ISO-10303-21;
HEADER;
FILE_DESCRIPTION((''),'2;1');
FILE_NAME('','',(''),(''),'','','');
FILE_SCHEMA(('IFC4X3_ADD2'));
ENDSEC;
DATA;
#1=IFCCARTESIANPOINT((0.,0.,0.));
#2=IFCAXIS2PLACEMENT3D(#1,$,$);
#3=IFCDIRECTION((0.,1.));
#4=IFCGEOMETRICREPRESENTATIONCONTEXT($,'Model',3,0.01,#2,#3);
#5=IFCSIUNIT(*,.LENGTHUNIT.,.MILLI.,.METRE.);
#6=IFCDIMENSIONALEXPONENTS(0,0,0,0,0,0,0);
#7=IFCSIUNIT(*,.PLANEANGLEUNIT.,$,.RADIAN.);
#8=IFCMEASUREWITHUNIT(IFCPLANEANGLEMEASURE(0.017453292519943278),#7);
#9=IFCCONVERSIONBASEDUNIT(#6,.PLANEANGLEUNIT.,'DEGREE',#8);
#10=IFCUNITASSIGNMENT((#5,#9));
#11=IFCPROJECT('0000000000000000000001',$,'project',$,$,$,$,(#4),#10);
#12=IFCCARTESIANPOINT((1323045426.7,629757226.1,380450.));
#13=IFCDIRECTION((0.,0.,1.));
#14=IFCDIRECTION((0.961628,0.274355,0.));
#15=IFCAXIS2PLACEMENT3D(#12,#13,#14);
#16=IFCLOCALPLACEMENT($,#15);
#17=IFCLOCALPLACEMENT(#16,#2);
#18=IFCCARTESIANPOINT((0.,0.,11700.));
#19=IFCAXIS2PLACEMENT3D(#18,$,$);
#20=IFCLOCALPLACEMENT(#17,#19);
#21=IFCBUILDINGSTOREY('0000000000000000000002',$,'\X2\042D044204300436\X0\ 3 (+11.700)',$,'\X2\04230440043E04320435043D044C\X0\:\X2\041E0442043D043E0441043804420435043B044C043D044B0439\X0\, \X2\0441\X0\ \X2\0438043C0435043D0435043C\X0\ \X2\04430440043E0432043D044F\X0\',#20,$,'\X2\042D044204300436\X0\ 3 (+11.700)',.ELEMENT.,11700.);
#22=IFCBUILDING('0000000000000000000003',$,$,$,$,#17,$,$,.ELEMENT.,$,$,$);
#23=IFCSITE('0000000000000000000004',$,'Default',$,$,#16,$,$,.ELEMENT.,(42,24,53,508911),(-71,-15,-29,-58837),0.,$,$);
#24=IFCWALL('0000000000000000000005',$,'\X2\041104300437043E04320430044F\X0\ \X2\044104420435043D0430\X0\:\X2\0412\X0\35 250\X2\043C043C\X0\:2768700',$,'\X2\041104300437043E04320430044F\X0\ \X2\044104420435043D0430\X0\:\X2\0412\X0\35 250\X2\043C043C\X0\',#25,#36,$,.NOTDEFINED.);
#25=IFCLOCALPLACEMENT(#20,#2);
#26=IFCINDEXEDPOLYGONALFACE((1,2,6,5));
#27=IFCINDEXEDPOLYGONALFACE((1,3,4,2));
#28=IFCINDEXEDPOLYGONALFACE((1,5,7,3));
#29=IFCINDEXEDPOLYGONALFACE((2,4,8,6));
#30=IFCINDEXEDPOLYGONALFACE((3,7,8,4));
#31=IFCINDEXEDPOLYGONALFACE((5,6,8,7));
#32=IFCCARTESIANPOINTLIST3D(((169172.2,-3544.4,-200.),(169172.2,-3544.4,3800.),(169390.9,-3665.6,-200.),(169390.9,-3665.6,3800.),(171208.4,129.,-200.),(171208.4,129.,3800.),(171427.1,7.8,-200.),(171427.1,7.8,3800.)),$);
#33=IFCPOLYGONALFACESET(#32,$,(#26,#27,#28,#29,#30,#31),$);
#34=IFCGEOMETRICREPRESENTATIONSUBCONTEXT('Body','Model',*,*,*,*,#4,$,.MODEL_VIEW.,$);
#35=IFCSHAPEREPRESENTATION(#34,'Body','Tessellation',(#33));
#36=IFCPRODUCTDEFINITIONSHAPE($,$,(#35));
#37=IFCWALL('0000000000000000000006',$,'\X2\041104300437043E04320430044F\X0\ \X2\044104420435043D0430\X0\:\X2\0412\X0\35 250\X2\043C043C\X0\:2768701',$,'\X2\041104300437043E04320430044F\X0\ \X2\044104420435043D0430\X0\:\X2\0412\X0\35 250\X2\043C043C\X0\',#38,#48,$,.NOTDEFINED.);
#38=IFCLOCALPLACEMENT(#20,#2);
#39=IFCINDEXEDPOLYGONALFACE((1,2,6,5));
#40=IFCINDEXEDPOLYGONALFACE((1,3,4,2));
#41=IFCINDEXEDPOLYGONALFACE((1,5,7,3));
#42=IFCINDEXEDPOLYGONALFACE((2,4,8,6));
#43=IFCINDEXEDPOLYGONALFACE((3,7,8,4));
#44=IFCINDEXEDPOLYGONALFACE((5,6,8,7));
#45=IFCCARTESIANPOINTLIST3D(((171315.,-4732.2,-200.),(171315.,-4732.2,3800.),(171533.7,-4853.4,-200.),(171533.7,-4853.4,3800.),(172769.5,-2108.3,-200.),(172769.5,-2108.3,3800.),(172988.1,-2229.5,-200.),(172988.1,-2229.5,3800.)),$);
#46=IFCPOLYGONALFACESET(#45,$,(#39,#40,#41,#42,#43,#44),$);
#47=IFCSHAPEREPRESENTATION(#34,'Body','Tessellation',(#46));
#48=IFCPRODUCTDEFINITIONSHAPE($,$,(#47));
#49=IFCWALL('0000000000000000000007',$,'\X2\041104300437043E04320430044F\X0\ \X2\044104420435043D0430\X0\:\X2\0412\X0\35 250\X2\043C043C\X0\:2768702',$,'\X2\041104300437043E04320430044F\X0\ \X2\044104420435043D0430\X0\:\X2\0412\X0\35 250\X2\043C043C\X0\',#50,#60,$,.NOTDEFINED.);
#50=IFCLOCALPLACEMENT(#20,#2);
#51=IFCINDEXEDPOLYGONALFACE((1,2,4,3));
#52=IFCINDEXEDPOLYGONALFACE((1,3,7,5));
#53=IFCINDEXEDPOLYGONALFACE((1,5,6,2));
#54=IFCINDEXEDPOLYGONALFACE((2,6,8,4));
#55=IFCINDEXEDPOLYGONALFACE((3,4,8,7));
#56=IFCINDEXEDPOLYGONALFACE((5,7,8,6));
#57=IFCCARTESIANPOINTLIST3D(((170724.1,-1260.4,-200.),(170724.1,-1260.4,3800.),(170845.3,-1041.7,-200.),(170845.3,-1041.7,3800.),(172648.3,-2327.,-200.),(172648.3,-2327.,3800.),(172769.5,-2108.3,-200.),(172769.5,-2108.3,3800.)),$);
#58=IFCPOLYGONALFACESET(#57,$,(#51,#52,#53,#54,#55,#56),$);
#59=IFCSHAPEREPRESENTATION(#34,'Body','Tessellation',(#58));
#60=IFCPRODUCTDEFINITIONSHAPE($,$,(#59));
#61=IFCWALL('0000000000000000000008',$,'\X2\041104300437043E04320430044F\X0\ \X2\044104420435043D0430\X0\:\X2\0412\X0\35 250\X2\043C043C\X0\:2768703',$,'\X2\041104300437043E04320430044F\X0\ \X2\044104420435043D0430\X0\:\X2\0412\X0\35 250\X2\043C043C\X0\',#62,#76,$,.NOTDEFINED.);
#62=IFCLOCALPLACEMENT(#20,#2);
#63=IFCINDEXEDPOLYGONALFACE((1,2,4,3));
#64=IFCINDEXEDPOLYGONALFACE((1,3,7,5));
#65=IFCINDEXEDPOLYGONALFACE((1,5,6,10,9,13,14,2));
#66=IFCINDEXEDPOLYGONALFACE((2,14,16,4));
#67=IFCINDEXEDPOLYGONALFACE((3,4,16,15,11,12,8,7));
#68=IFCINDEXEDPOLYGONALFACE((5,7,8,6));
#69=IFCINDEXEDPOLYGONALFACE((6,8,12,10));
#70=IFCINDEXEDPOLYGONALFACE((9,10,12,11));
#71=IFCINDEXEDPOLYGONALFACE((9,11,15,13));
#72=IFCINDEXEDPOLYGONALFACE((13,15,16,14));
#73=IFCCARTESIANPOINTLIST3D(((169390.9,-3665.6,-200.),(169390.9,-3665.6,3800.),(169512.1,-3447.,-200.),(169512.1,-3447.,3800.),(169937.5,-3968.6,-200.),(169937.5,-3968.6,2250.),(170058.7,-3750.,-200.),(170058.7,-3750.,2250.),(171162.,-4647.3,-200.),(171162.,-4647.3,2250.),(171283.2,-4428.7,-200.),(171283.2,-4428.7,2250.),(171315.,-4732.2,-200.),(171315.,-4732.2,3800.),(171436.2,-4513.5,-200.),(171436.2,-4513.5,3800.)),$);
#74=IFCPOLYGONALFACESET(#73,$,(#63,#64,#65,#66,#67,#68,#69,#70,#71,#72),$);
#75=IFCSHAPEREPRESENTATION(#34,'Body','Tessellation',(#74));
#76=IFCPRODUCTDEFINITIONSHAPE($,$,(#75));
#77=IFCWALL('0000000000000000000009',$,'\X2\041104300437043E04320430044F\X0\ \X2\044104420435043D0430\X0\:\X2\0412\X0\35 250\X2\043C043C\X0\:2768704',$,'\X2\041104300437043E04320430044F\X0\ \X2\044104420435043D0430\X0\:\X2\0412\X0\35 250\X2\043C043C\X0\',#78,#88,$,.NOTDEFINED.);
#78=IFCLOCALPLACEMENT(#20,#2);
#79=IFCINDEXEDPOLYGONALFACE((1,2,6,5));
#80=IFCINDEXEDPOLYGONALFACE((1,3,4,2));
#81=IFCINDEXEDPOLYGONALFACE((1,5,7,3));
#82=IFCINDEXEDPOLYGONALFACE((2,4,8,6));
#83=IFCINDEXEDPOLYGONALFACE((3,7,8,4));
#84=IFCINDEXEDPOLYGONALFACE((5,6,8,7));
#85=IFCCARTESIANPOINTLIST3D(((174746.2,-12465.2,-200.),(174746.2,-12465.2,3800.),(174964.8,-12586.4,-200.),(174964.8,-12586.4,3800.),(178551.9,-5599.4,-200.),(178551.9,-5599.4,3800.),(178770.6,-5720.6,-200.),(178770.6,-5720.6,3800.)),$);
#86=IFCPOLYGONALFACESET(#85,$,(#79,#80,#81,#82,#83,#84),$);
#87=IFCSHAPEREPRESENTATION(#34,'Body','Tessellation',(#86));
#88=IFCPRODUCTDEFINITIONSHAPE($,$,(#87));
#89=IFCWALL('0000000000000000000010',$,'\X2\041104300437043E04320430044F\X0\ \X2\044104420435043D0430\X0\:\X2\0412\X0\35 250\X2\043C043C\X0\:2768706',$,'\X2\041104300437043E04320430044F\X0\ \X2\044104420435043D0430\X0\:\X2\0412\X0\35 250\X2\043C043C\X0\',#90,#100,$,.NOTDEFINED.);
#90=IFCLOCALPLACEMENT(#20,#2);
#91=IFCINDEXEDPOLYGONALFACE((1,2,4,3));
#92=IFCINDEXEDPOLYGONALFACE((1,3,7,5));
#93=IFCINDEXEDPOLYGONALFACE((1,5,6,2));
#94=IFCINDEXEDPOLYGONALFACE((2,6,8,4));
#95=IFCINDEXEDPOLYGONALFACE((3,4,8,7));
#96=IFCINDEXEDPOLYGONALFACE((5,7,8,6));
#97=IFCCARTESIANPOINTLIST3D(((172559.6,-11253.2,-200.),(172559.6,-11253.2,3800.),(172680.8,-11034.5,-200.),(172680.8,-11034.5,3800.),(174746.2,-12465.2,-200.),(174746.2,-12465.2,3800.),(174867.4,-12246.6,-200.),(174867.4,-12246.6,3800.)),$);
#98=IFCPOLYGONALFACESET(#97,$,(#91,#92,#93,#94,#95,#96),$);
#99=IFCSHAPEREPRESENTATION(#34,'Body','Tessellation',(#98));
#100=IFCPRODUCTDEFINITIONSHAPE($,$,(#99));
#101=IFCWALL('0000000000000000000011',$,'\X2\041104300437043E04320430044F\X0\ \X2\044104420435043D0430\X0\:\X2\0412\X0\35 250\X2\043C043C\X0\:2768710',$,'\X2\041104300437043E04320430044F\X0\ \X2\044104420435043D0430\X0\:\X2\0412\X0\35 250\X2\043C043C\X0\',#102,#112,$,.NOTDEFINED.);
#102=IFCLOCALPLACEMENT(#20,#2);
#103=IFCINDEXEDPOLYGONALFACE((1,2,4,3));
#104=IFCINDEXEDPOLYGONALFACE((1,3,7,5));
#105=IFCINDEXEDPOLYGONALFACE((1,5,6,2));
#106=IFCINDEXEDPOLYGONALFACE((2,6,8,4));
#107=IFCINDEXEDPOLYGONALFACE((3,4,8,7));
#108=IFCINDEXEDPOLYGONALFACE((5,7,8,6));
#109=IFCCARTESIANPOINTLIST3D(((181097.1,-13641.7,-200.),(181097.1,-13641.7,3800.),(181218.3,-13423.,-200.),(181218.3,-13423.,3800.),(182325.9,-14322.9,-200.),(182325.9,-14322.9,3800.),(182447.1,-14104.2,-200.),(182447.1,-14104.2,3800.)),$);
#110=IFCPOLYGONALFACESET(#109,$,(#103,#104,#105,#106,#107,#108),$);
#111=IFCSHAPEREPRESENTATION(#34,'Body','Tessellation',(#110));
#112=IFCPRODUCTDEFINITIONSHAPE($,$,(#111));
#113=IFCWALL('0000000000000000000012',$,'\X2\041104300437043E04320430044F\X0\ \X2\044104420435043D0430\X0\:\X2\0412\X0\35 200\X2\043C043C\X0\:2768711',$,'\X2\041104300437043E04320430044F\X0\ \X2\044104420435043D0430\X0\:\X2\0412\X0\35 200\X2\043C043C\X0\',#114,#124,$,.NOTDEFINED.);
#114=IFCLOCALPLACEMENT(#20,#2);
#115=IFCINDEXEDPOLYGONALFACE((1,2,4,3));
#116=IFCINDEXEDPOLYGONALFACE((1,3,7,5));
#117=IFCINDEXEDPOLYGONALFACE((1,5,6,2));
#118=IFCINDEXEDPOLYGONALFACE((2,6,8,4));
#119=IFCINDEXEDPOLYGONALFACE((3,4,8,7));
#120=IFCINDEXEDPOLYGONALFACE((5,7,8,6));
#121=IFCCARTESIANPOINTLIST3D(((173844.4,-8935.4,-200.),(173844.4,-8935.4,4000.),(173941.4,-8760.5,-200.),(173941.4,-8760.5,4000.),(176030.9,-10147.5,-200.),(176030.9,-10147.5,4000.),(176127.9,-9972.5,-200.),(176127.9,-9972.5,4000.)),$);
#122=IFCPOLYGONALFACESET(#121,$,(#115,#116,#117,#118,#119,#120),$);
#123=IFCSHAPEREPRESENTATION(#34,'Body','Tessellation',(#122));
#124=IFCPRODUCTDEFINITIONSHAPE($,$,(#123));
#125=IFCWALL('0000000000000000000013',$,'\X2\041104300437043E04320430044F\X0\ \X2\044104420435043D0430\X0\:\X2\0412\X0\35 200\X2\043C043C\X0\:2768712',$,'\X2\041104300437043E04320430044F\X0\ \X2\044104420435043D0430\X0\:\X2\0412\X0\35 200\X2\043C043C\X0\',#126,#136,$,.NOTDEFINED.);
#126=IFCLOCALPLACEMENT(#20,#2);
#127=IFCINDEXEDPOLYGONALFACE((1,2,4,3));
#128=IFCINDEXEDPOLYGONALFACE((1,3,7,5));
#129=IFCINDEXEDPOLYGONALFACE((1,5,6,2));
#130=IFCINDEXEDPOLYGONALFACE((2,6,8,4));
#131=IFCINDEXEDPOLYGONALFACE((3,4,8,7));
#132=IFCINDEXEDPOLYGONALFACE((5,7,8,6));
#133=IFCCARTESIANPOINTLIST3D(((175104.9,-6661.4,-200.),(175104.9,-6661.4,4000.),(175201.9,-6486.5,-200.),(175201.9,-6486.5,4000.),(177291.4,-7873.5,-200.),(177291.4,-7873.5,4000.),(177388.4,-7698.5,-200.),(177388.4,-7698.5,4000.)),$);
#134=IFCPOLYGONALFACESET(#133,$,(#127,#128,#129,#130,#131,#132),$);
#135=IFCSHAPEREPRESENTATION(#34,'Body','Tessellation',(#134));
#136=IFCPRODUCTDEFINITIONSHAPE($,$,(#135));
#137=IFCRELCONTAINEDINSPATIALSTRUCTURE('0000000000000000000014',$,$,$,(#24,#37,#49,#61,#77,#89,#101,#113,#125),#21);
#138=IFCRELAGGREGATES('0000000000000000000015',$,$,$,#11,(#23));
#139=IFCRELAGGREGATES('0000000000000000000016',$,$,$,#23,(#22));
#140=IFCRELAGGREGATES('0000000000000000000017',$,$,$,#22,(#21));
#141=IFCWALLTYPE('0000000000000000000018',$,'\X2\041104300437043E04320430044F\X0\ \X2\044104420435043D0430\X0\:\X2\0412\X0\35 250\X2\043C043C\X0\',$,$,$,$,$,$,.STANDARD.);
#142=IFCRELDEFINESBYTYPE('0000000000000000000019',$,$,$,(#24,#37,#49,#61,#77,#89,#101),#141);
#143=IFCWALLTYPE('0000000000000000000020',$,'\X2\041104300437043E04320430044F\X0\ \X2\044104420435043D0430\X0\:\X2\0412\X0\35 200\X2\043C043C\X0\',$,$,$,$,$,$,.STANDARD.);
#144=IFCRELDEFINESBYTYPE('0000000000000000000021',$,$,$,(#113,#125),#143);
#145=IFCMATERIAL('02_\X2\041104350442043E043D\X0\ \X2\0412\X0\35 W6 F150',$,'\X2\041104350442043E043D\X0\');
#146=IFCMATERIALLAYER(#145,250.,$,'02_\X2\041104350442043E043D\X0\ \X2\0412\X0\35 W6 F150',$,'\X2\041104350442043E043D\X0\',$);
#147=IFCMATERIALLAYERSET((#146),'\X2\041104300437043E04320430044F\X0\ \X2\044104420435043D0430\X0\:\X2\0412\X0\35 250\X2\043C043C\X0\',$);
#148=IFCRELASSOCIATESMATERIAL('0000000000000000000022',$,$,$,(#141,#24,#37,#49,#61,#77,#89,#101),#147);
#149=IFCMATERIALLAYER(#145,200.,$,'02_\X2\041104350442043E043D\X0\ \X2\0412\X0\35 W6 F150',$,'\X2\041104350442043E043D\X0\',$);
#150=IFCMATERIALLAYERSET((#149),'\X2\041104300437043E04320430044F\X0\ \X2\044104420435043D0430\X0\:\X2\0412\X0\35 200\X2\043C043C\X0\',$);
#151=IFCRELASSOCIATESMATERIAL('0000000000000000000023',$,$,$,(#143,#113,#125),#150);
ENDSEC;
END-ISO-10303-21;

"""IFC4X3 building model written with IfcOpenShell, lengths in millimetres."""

from ifc_helpers import new_model, entity, si_unit, converted_unit, direction, frame, frame_2d, origin, origin_2d_with_axis, place, context, subcontext, project, spatial, rectangle, extrude, material, layer, layer_set, type_object, element, save


model = new_model("IFC4X3")

# Units and contexts
model_context = context("Model", 3, precision=0.01, world=origin(), true_north=direction((0.0, 1.0)))
body_context = subcontext(model_context, "Body", "Model", "MODEL_VIEW")
ifc_project = project(units=[si_unit("LENGTHUNIT", "METRE", prefix="MILLI"), converted_unit("PLANEANGLEUNIT", "DEGREE", entity("IfcPlaneAngleMeasure", 0.017453292519943278), si_unit("PLANEANGLEUNIT", "RADIAN"), dimensions=[0, 0, 0, 0, 0, 0, 0])], contexts=[model_context])

# Site, building, storey
site_placement = place(None, frame((1323045426.7, 629757226.1, 380450.0), z_axis=(0.0, 0.0, 1.0), x_axis=(0.961628, 0.274355, 0.0)))
site = spatial("IfcSite", under=ifc_project, at=site_placement, Name="Default", CompositionType="ELEMENT", RefLatitude=(42, 24, 53, 508911), RefLongitude=(-71, -15, -29, -58837), RefElevation=0.0)
building_placement = place(site_placement, origin())
building = spatial("IfcBuilding", under=site, at=building_placement, CompositionType="ELEMENT")
storey_placement = place(building_placement, frame((0.0, 0.0, 11700.0)))
storey = spatial("IfcBuildingStorey", under=building, at=storey_placement, Name="Этаж 3 (+11.700)", ObjectType="Уровень:Относительный, с именем уровня", LongName="Этаж 3 (+11.700)", CompositionType="ELEMENT", Elevation=11700.0)

# Shared definitions
ifc_material = material(Name="02_Бетон В35 W6 F150", Category="Бетон")
ifc_layer_1 = layer(ifc_material, 250.0, Name="02_Бетон В35 W6 F150", Category="Бетон")
ifc_layer_set_1 = layer_set([ifc_layer_1], Name="Базовая стена:В35 250мм")
wall_type_1 = type_object("IfcWallType", Name="Базовая стена:В35 250мм", PredefinedType="STANDARD", material=ifc_layer_set_1)

# Walls
wall_1_placement = place(storey_placement, frame((169281.5, -3605.0, -200.0), z_axis=(0.0, 0.0, 1.0), x_axis=(0.48481, 0.87462, 0.0)))
element("IfcWall", 1, at=wall_1_placement, inside=storey, type_object=wall_type_1, material=ifc_layer_set_1, Name="Базовая стена:В35 250мм:2768700", ObjectType="Базовая стена:В35 250мм", PredefinedType="NOTDEFINED", context=body_context, shape_type="SweptSolid", body=[
    extrude(rectangle(XDim=4200.0, YDim=250.0, at=frame_2d((2100.0, 0.0), x_axis=(-1.0, 0.0))), origin(), (0.0, 0.0, 1.0), 4000.0),
])
wall_2_placement = place(storey_placement, frame((171424.4, -4792.8, -200.0), z_axis=(0.0, 0.0, 1.0), x_axis=(0.48481, 0.87462, 0.0)))
element("IfcWall", 2, at=wall_2_placement, inside=storey, type_object=wall_type_1, material=ifc_layer_set_1, Name="Базовая стена:В35 250мм:2768701", ObjectType="Базовая стена:В35 250мм", PredefinedType="NOTDEFINED", context=body_context, shape_type="SweptSolid", body=[
    extrude(rectangle(XDim=3000.0, YDim=250.0, at=frame_2d((1500.0, 0.0), x_axis=(-1.0, 0.0))), origin(), (0.0, 0.0, 1.0), 4000.0),
])
wall_3_placement = place(storey_placement, frame((172708.9, -2217.7, -200.0), z_axis=(0.0, 0.0, 1.0), x_axis=(-0.87462, 0.48481, 0.0)))
element("IfcWall", 3, at=wall_3_placement, inside=storey, type_object=wall_type_1, material=ifc_layer_set_1, Name="Базовая стена:В35 250мм:2768702", ObjectType="Базовая стена:В35 250мм", PredefinedType="NOTDEFINED", context=body_context, shape_type="SweptSolid", body=[
    extrude(rectangle(XDim=2200.0, YDim=250.0, at=frame_2d((1100.0, 0.0), x_axis=(-1.0, 0.0))), origin(), (0.0, 0.0, 1.0), 4000.0),
])

# Wall, opening
wall_4_placement = place(storey_placement, frame((171375.6, -4622.9, -200.0), z_axis=(0.0, 0.0, 1.0), x_axis=(-0.87462, 0.48481, 0.0)))
wall_4 = element("IfcWall", 4, at=wall_4_placement, inside=storey, type_object=wall_type_1, material=ifc_layer_set_1, Name="Базовая стена:В35 250мм:2768703", ObjectType="Базовая стена:В35 250мм", PredefinedType="NOTDEFINED", context=body_context, shape_type="SweptSolid", body=[
    extrude(rectangle(XDim=2200.0, YDim=250.0, at=frame_2d((1100.0, 0.0), x_axis=(-1.0, 0.0))), origin(), (0.0, 0.0, 1.0), 4000.0),
])
opening_1_placement = place(wall_4_placement, frame((152129.7, 79041.3, 0.0), z_axis=(0.0, 0.0, 1.0), x_axis=(-0.87462, -0.48481, 0.0)))
element("IfcOpeningElement", 5, at=opening_1_placement, cuts=wall_4, PredefinedType="OPENING", context=body_context, shape_type="SweptSolid", body=[
    extrude(rectangle(XDim=2450.0, YDim=1400.0, at=origin_2d_with_axis()), frame((171409.8, -2756.4, 1225.0), z_axis=(-0.48481, -0.87462, 0.0), x_axis=(0.0, 0.0, -1.0)), (0.0, 0.0, 1.0), 3048.0),
])

# Wall
wall_5_placement = place(storey_placement, frame((174855.5, -12525.8, -200.0), z_axis=(0.0, 0.0, 1.0), x_axis=(0.48481, 0.87462, 0.0)))
element("IfcWall", 6, at=wall_5_placement, inside=storey, type_object=wall_type_1, material=ifc_layer_set_1, Name="Базовая стена:В35 250мм:2768704", ObjectType="Базовая стена:В35 250мм", PredefinedType="NOTDEFINED", context=body_context, shape_type="SweptSolid", body=[
    extrude(rectangle(XDim=7850.0, YDim=250.0, at=frame_2d((3925.0, 0.0), x_axis=(-1.0, 0.0))), origin(), (0.0, 0.0, 1.0), 4000.0),
])

# Wall
wall_6_placement = place(storey_placement, frame((172620.2, -11143.9, -200.0), z_axis=(0.0, 0.0, 1.0), x_axis=(0.87462, -0.48481, 0.0)))
element("IfcWall", 7, at=wall_6_placement, inside=storey, type_object=wall_type_1, material=ifc_layer_set_1, Name="Базовая стена:В35 250мм:2768706", ObjectType="Базовая стена:В35 250мм", PredefinedType="NOTDEFINED", context=body_context, shape_type="SweptSolid", body=[
    extrude(rectangle(XDim=2500.0, YDim=250.0, at=frame_2d((1250.0, 0.0), x_axis=(-1.0, 0.0))), origin(), (0.0, 0.0, 1.0), 4000.0),
])

# Wall
wall_7_placement = place(storey_placement, frame((181157.7, -13532.4, -200.0), z_axis=(0.0, 0.0, 1.0), x_axis=(0.87462, -0.48481, 0.0)))
element("IfcWall", 8, at=wall_7_placement, inside=storey, type_object=wall_type_1, material=ifc_layer_set_1, Name="Базовая стена:В35 250мм:2768710", ObjectType="Базовая стена:В35 250мм", PredefinedType="NOTDEFINED", context=body_context, shape_type="SweptSolid", body=[
    extrude(rectangle(XDim=1405.0, YDim=250.0, at=frame_2d((702.5, 0.0), x_axis=(-1.0, 0.0))), origin(), (0.0, 0.0, 1.0), 4000.0),
])

# Walls
ifc_layer_2 = layer(ifc_material, 200.0, Name="02_Бетон В35 W6 F150", Category="Бетон")
ifc_layer_set_2 = layer_set([ifc_layer_2], Name="Базовая стена:В35 200мм")
wall_type_2 = type_object("IfcWallType", Name="Базовая стена:В35 200мм", PredefinedType="STANDARD", material=ifc_layer_set_2)
wall_8_placement = place(storey_placement, frame((173892.9, -8848.0, -200.0), z_axis=(0.0, 0.0, 1.0), x_axis=(0.87462, -0.48481, 0.0)))
element("IfcWall", 9, at=wall_8_placement, inside=storey, type_object=wall_type_2, material=ifc_layer_set_2, Name="Базовая стена:В35 200мм:2768711", ObjectType="Базовая стена:В35 200мм", PredefinedType="NOTDEFINED", context=body_context, shape_type="SweptSolid", body=[
    extrude(rectangle(XDim=2500.0, YDim=200.0, at=frame_2d((1250.0, 0.0), x_axis=(-1.0, 0.0))), origin(), (0.0, 0.0, 1.0), 4200.0),
])
wall_9_placement = place(storey_placement, frame((175153.4, -6574.0, -200.0), z_axis=(0.0, 0.0, 1.0), x_axis=(0.87462, -0.48481, 0.0)))
element("IfcWall", 10, at=wall_9_placement, inside=storey, type_object=wall_type_2, material=ifc_layer_set_2, Name="Базовая стена:В35 200мм:2768712", ObjectType="Базовая стена:В35 200мм", PredefinedType="NOTDEFINED", context=body_context, shape_type="SweptSolid", body=[
    extrude(rectangle(XDim=2500.0, YDim=200.0, at=frame_2d((1250.0, 0.0), x_axis=(-1.0, 0.0))), origin(), (0.0, 0.0, 1.0), 4200.0),
])

save(model, "model.ifc")
